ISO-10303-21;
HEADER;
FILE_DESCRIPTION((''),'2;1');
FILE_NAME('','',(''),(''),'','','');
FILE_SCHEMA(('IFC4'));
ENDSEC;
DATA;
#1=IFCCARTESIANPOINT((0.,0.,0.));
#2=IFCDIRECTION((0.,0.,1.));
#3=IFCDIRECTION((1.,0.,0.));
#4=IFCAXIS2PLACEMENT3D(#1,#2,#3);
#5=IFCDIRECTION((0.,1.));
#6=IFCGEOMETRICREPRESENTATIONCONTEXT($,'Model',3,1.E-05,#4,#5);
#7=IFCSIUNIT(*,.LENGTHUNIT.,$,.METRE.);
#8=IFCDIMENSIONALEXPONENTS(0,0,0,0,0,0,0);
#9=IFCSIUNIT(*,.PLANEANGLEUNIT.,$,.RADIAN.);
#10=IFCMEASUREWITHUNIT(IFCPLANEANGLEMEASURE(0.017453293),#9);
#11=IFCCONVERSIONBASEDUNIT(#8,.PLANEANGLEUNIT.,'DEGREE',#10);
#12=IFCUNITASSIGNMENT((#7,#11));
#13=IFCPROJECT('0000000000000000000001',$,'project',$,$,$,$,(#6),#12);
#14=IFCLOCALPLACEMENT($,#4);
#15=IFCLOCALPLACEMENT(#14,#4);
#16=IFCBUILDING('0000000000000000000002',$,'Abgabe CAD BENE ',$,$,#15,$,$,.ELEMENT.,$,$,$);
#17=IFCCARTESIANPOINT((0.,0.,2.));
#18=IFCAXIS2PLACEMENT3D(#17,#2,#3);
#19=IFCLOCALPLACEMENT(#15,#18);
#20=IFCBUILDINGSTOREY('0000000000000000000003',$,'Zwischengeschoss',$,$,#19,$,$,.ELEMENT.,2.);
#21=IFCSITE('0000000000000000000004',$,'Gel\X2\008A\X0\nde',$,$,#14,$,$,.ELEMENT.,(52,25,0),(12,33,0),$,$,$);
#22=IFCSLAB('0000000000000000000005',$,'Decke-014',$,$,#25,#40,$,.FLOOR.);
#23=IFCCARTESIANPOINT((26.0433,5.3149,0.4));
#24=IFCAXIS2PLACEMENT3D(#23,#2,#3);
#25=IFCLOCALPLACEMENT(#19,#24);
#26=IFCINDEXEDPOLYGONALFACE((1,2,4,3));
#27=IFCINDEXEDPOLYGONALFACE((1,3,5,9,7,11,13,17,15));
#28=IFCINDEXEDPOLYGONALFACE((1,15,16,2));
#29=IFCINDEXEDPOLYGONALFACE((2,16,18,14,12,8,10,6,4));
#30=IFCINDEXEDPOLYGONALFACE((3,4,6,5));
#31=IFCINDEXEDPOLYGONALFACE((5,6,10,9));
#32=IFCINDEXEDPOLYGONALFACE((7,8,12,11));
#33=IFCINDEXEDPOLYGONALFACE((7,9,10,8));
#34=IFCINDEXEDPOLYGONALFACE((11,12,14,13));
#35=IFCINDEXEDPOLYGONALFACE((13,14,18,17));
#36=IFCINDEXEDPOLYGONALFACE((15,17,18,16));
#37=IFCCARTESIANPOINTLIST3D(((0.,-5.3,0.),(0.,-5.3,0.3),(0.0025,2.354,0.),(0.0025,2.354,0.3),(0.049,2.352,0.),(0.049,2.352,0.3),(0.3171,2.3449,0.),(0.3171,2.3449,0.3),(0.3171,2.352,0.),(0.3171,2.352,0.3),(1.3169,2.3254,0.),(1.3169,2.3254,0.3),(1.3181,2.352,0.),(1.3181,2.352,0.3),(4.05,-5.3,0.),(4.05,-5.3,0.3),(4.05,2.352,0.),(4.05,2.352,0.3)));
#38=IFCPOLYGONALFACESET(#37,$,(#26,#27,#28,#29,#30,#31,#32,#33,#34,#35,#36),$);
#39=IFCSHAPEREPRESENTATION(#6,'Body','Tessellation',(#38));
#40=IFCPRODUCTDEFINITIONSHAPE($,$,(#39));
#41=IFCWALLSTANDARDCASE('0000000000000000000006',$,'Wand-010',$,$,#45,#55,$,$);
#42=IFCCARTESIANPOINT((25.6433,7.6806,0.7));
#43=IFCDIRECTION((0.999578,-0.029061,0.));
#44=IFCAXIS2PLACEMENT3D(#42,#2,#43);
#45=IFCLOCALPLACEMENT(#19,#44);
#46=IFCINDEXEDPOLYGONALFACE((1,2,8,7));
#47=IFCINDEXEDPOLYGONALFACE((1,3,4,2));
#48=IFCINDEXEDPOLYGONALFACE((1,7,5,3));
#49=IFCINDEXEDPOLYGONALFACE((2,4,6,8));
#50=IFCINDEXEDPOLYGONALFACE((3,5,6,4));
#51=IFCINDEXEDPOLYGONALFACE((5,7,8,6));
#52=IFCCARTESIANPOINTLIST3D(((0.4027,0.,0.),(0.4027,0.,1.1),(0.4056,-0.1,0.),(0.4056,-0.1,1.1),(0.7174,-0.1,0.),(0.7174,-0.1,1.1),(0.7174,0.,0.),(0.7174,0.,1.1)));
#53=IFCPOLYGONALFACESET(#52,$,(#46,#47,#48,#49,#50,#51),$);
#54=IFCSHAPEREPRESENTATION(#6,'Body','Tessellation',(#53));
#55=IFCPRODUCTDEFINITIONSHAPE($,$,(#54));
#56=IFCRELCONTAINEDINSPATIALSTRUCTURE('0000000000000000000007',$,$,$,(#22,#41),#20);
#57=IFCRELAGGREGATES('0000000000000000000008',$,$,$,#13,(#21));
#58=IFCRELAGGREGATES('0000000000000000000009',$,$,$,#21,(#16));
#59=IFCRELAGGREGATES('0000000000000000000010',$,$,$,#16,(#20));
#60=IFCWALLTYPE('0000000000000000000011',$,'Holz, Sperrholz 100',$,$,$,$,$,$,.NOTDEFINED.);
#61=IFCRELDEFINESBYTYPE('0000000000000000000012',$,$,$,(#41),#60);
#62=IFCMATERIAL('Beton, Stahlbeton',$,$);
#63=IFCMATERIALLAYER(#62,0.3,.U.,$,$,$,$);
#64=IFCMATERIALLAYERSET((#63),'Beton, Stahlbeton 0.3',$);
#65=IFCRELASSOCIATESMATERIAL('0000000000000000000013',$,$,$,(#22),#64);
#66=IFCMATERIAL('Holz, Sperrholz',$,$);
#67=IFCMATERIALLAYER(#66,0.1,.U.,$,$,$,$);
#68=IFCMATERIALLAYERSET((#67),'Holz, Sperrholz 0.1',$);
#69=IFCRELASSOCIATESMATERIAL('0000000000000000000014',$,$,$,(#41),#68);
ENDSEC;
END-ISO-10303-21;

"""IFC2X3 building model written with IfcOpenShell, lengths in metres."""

from ifc_helpers import new_model, entity, si_unit, converted_unit, direction, frame, origin_with_axes, place, context, project, spatial, polyline, outline, extrude, material, layer, layer_set, layer_usage, type_object, element, save


model = new_model("IFC2X3")

# Units and contexts
model_context = context("Model", 3, precision=1e-05, world=origin_with_axes(), true_north=direction((0.0, 1.0)))
ifc_project = project(units=[si_unit("LENGTHUNIT", "METRE"), converted_unit("PLANEANGLEUNIT", "DEGREE", entity("IfcPlaneAngleMeasure", 0.017453293), si_unit("PLANEANGLEUNIT", "RADIAN"), dimensions=[0, 0, 0, 0, 0, 0, 0])], contexts=[model_context])

# Site, building, storey
site_placement = place(None, origin_with_axes())
site = spatial("IfcSite", under=ifc_project, at=site_placement, Name="Gel\u008ande", CompositionType="ELEMENT", RefLatitude=(52, 25, 0), RefLongitude=(12, 33, 0))
building_placement = place(site_placement, origin_with_axes())
building = spatial("IfcBuilding", under=site, at=building_placement, Name="Abgabe CAD BENE ", CompositionType="ELEMENT")
storey_placement = place(building_placement, frame((0.0, 0.0, 2.0), z_axis=(0.0, 0.0, 1.0), x_axis=(1.0, 0.0, 0.0)))
storey = spatial("IfcBuildingStorey", under=building, at=storey_placement, Name="Zwischengeschoss", CompositionType="ELEMENT", Elevation=2.0)

# Slab
ifc_material_1 = material(Name="Beton, Stahlbeton")
ifc_layer_1 = layer(ifc_material_1, 0.3, ventilated="UNKNOWN")
ifc_layer_set_1 = layer_set([ifc_layer_1], Name="Beton, Stahlbeton 0.3")
ifc_layer_usage_1 = layer_usage(ifc_layer_set_1, "AXIS3", "NEGATIVE", 0.3)
slab_placement = place(storey_placement, frame((26.0433, 5.3149, 0.4), z_axis=(0.0, 0.0, 1.0), x_axis=(1.0, 0.0, 0.0)))
element("IfcSlab", 1, at=slab_placement, inside=storey, material=ifc_layer_usage_1, Name="Decke-014", PredefinedType="FLOOR", context=model_context, shape_type="SweptSolid", body=[
    extrude(outline(polyline([(0.0, -5.3), (4.05, -5.3), (4.05, 2.352), (1.3181, 2.352), (1.3169, 2.3254), (0.3171, 2.3449), (0.3171, 2.352), (0.049, 2.352), (0.0025, 2.354), (0.0, -5.3)])), origin_with_axes(), (0.0, 0.0, 1.0), 0.3),
])

# Wall
ifc_material_2 = material(Name="Holz, Sperrholz")
ifc_layer_2 = layer(ifc_material_2, 0.1, ventilated="UNKNOWN")
ifc_layer_set_2 = layer_set([ifc_layer_2], Name="Holz, Sperrholz 0.1")
wall_type_1 = type_object("IfcWallType", Name="Holz, Sperrholz 100", PredefinedType="NOTDEFINED")
ifc_layer_usage_2 = layer_usage(ifc_layer_set_2, "AXIS2", "NEGATIVE", 0.0)
wall_1_placement = place(storey_placement, frame((25.6433, 7.6806, 0.7), z_axis=(0.0, 0.0, 1.0), x_axis=(0.999578, -0.029061, 0.0)))
element("IfcWallStandardCase", 2, at=wall_1_placement, inside=storey, type_object=wall_type_1, material=ifc_layer_usage_2, Name="Wand-010", context=model_context, shape_type="SweptSolid", body=[
    extrude(outline(polyline([(0.4056, -0.1), (0.7174, -0.1), (0.7174, 0.0), (0.4027, 0.0), (0.4056, -0.1)])), origin_with_axes(), (0.0, 0.0, 1.0), 1.1),
])

save(model, "model.ifc")
